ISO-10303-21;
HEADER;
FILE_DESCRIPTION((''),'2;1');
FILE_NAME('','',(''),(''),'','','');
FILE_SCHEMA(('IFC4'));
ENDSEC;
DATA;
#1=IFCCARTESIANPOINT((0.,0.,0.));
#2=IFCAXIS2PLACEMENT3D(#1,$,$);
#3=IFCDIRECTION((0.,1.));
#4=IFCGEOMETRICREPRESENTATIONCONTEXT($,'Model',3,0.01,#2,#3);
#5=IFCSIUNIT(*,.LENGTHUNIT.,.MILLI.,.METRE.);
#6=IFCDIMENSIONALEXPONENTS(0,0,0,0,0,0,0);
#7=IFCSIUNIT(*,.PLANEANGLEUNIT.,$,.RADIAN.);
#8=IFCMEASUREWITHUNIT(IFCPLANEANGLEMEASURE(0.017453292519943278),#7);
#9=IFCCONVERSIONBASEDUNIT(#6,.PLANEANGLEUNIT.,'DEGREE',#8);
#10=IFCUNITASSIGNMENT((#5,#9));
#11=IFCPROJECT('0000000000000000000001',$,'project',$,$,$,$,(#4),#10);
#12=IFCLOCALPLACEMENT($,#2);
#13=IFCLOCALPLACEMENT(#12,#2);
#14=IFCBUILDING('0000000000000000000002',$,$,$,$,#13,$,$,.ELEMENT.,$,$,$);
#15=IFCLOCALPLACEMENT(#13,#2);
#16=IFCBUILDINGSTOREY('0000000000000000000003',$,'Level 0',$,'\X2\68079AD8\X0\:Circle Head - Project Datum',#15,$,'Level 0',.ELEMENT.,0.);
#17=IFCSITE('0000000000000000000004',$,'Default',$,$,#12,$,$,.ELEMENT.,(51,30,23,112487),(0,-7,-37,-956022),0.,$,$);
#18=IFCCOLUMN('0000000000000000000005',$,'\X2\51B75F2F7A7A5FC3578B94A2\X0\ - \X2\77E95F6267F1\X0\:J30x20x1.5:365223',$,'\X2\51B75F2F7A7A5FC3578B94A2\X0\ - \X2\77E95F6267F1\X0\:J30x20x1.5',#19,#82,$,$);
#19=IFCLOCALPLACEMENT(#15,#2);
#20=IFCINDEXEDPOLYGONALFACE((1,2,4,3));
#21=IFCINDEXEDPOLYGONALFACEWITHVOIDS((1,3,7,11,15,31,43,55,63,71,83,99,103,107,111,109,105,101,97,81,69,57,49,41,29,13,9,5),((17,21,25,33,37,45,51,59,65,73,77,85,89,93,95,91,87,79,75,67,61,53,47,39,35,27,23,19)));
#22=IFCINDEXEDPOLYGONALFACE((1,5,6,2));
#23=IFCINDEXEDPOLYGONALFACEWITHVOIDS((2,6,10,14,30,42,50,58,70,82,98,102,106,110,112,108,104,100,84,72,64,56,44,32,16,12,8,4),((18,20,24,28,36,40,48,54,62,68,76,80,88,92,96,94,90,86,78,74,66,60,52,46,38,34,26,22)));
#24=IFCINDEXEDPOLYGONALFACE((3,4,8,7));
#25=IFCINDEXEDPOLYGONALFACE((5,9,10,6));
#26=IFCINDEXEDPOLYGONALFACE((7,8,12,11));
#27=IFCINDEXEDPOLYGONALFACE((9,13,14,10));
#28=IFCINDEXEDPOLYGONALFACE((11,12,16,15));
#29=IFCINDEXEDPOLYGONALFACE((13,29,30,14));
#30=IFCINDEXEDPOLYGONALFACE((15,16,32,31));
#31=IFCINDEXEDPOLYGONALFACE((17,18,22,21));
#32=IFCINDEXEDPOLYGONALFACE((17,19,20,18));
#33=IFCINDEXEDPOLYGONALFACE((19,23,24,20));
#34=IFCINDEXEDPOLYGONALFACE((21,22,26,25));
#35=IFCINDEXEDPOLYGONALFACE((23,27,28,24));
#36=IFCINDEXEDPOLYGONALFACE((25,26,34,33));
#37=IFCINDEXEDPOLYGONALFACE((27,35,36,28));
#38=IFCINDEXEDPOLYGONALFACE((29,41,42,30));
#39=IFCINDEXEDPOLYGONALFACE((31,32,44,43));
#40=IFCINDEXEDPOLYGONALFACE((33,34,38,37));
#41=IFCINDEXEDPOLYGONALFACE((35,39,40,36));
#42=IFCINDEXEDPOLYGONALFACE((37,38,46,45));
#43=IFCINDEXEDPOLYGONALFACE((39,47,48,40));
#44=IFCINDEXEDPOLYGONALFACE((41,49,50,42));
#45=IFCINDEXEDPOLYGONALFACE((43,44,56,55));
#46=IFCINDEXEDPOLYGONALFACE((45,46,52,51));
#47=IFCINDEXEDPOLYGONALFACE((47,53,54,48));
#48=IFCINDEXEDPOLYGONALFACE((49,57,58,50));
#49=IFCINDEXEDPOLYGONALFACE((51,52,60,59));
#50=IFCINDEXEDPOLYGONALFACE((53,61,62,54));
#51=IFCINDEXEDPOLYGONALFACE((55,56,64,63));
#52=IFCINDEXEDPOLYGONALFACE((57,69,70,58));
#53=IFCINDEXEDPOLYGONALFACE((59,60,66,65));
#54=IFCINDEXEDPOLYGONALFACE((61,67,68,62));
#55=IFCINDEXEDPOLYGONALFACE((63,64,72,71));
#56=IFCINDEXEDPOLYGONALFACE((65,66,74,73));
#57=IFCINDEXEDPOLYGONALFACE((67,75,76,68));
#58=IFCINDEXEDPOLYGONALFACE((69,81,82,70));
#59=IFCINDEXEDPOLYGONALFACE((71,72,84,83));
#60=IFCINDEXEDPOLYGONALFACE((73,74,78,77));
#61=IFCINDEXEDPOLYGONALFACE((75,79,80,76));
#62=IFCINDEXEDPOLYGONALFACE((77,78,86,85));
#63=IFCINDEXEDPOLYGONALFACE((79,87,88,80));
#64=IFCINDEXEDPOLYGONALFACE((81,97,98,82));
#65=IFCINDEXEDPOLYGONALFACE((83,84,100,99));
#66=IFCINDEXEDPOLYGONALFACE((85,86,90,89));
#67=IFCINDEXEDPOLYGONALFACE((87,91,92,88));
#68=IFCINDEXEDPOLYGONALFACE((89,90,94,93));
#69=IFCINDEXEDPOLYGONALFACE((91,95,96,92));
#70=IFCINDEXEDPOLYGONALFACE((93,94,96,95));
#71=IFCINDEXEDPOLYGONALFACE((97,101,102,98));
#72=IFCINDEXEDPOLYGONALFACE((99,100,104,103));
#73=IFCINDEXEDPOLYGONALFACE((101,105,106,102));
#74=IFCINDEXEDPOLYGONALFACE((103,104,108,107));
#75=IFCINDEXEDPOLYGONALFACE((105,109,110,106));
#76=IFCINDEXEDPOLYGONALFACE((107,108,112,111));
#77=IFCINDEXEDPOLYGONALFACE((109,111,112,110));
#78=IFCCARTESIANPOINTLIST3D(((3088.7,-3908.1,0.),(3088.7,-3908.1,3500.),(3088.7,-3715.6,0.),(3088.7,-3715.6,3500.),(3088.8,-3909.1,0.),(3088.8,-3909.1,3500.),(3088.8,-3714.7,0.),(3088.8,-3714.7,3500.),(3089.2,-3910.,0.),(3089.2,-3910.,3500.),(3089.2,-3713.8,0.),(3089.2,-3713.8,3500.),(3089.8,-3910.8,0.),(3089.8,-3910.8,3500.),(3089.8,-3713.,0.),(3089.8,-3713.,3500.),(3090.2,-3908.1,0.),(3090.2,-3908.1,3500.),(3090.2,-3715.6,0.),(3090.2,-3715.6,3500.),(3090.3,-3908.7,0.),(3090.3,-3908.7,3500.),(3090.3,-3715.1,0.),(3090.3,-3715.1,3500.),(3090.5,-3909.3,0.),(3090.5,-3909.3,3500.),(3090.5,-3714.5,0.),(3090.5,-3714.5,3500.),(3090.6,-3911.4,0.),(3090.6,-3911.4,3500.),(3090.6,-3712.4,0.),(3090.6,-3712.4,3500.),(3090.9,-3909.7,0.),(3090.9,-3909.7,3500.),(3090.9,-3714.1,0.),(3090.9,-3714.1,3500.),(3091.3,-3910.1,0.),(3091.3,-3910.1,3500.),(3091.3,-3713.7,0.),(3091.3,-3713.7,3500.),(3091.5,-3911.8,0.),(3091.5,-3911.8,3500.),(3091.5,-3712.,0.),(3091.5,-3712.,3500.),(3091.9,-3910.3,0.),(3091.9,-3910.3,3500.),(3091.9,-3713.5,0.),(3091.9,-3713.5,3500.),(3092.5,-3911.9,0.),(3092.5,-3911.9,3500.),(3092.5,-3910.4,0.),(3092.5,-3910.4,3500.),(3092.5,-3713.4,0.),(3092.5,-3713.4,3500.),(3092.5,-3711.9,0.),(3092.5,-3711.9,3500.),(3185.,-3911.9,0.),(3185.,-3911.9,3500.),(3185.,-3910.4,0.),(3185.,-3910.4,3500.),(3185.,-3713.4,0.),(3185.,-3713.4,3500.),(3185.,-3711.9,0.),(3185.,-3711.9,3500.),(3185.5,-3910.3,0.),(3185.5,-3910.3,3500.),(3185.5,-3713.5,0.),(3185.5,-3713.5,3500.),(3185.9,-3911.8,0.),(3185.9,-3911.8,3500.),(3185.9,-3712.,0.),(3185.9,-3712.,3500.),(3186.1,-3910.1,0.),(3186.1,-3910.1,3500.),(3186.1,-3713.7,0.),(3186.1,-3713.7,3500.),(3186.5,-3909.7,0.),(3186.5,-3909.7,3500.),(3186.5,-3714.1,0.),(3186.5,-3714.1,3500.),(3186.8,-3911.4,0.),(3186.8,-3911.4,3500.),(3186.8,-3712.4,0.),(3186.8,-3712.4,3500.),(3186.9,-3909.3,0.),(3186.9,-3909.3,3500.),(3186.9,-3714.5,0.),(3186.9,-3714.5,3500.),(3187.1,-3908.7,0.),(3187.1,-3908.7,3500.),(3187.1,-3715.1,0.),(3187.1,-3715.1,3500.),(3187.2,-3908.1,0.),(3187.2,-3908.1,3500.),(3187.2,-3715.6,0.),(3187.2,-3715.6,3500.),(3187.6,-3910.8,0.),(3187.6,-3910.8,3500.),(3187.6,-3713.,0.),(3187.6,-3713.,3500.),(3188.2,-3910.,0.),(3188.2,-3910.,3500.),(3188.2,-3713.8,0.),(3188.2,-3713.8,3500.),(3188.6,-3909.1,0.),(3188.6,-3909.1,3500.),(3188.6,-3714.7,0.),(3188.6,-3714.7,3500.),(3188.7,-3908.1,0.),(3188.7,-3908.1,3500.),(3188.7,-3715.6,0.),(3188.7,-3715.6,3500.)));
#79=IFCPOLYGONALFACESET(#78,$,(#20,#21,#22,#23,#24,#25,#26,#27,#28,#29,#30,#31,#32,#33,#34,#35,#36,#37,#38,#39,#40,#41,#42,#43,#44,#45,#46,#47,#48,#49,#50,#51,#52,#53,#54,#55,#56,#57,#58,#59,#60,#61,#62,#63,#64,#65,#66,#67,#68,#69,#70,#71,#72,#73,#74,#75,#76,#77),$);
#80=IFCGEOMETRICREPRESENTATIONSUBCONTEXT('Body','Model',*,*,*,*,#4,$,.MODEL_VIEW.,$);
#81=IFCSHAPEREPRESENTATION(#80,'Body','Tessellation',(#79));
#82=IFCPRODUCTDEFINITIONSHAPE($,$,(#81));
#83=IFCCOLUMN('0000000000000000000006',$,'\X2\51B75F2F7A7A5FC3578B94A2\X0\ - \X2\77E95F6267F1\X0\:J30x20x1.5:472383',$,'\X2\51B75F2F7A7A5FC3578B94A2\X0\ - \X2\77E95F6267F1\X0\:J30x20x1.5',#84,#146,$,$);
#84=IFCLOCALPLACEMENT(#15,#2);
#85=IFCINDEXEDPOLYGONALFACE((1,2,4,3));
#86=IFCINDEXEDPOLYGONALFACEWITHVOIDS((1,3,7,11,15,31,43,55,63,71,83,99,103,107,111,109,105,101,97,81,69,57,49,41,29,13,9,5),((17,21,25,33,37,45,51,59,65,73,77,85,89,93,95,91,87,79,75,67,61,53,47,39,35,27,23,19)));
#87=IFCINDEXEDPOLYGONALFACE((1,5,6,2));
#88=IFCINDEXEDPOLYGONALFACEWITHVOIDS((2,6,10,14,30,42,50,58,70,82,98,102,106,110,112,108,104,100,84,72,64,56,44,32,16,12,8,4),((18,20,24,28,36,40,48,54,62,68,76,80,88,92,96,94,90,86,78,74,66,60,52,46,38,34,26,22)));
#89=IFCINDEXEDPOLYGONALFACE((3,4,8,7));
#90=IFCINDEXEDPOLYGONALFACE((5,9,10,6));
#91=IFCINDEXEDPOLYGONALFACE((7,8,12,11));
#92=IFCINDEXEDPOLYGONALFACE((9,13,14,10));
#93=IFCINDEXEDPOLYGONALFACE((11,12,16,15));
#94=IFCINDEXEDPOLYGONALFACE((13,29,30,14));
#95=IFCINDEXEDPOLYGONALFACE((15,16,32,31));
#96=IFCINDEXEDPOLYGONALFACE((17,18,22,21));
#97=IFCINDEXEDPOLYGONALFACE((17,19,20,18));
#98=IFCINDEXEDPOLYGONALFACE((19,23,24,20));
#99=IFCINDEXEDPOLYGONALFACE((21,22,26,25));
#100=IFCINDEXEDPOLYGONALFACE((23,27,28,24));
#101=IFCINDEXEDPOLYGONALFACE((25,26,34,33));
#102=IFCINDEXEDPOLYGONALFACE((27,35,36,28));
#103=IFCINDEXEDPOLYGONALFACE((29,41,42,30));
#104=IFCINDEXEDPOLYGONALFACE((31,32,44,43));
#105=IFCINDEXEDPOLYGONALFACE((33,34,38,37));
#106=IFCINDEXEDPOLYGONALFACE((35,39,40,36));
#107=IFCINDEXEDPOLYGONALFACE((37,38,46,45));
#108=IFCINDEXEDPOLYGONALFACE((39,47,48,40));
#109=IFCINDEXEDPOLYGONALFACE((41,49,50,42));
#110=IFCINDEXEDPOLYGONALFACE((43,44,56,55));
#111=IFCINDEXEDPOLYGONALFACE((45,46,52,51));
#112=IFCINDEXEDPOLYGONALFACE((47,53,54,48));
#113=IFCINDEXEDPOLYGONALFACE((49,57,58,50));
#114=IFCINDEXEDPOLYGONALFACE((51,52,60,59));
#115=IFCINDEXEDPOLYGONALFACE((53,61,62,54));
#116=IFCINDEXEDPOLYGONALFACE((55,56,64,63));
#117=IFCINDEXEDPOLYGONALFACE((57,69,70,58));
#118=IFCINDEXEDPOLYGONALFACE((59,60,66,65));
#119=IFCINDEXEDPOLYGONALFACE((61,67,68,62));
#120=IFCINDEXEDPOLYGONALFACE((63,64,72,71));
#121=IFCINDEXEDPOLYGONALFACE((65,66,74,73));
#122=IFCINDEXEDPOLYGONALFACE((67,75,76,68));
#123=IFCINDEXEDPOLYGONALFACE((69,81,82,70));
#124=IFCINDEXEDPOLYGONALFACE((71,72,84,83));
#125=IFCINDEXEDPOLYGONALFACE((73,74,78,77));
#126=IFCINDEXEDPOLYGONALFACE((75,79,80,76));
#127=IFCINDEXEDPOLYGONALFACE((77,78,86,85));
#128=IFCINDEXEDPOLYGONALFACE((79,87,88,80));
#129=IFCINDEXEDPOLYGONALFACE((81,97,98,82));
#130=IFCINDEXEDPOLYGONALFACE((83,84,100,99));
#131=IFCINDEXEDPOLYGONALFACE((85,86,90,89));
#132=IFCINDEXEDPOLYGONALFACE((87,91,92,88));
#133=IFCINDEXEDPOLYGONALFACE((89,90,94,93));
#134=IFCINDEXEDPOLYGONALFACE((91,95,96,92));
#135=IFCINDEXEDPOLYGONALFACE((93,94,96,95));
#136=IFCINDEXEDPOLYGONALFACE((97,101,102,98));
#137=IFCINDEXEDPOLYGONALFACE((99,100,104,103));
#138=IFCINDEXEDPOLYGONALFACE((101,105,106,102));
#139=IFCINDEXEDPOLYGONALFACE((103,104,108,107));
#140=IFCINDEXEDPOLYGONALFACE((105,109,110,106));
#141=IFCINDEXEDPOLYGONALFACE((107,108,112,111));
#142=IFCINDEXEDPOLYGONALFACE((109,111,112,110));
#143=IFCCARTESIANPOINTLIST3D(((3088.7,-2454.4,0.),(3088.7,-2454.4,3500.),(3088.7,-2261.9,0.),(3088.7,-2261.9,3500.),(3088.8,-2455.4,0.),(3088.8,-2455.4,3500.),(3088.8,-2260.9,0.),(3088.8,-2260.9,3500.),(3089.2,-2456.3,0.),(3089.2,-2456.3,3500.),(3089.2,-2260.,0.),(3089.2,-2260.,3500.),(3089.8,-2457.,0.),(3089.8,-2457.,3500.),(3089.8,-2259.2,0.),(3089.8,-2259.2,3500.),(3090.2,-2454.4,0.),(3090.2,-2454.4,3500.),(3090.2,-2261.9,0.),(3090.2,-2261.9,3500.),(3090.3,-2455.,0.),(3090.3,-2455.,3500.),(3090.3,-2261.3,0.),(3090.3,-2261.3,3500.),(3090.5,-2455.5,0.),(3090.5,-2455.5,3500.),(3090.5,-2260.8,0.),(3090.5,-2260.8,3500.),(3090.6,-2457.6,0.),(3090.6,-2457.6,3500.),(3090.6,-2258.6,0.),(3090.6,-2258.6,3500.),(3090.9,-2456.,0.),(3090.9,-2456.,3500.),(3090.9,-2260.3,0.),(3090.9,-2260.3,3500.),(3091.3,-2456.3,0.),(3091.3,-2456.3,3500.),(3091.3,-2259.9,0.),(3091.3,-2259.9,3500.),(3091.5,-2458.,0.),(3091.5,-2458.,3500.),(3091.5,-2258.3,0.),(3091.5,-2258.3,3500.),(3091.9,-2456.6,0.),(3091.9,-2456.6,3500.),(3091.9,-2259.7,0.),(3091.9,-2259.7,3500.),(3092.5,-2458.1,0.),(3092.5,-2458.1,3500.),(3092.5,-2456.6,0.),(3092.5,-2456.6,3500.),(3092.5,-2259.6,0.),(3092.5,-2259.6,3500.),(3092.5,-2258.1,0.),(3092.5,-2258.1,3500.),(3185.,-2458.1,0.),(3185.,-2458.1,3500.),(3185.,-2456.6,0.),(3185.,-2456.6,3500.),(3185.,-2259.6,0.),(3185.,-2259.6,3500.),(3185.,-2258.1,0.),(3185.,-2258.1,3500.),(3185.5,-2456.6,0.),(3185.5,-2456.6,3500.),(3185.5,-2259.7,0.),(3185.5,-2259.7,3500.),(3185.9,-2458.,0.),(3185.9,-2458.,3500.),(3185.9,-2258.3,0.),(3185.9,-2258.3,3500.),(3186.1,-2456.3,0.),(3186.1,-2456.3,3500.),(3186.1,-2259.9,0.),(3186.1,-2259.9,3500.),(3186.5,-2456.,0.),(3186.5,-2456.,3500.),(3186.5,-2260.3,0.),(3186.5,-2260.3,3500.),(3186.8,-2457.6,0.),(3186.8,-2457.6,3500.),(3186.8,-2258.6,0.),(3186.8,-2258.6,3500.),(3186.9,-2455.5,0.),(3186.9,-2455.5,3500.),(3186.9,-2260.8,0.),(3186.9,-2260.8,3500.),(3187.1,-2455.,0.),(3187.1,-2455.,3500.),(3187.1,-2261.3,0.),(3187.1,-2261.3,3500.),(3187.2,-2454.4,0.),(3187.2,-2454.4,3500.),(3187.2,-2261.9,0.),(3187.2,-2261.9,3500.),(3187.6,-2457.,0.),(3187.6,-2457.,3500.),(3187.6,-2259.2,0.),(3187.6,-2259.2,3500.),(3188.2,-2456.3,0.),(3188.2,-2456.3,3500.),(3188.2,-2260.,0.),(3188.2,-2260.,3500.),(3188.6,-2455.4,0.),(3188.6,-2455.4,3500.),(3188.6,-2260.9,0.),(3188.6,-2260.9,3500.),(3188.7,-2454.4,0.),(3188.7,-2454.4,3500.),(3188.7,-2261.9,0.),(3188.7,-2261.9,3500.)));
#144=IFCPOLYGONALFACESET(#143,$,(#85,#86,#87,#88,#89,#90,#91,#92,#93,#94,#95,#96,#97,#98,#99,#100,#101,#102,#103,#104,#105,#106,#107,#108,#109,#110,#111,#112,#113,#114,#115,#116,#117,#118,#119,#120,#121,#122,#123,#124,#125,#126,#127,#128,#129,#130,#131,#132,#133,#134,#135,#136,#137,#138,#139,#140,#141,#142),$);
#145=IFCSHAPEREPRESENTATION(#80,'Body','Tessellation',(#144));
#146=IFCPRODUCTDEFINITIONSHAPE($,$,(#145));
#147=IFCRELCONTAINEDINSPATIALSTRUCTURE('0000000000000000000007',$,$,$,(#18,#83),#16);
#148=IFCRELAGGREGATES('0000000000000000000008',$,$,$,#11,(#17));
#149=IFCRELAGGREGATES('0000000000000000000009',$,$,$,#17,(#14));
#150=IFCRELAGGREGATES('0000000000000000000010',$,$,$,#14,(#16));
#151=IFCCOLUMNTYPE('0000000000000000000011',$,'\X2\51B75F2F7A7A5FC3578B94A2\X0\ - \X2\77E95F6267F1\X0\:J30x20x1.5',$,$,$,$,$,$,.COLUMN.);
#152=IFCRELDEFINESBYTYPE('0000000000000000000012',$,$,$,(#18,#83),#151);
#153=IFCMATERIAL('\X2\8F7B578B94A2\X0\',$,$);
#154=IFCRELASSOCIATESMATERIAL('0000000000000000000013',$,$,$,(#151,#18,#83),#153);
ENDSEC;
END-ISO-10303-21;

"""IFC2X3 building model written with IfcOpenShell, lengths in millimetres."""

from ifc_helpers import new_model, entity, si_unit, converted_unit, direction, frame, frame_2d, origin, place, context, subcontext, project, spatial, polyline, circle_curve, parameter, trimmed, segment, composite_curve, outline, extrude, source, transform, mapped, material, type_object, type_shapes, element, save


model = new_model("IFC2X3")

# Units and contexts
model_context = context("Model", 3, precision=0.01, world=origin(), true_north=direction((0.0, 1.0)))
body_context = subcontext(model_context, "Body", "Model", "MODEL_VIEW")
ifc_project = project(units=[si_unit("LENGTHUNIT", "METRE", prefix="MILLI"), converted_unit("PLANEANGLEUNIT", "DEGREE", entity("IfcPlaneAngleMeasure", 0.017453292519943278), si_unit("PLANEANGLEUNIT", "RADIAN"), dimensions=[0, 0, 0, 0, 0, 0, 0])], contexts=[model_context])

# Site, building, storey
site_placement = place(None, origin())
site = spatial("IfcSite", under=ifc_project, at=site_placement, Name="Default", CompositionType="ELEMENT", RefLatitude=(51, 30, 23, 112487), RefLongitude=(0, -7, -37, -956022), RefElevation=0.0)
building_placement = place(site_placement, origin())
building = spatial("IfcBuilding", under=site, at=building_placement, CompositionType="ELEMENT")
storey_placement = place(building_placement, origin())
storey = spatial("IfcBuildingStorey", under=building, at=storey_placement, Name="Level 0", ObjectType="标高:Circle Head - Project Datum", LongName="Level 0", CompositionType="ELEMENT", Elevation=0.0)

# Columns
ifc_material_1 = material(Name="轻型钢")
column_type = type_object("IfcColumnType", Name="冷弯空心型钢 - 矩形柱:J30x20x1.5", PredefinedType="COLUMN", material=ifc_material_1)
shared_shape = source(origin(), body_context, "Body", "SweptSolid", [
    extrude(outline(composite_curve([segment(polyline([(-46.2, -100.0), (46.3, -100.0)]), True, "CONTINUOUS"), segment(trimmed(circle_curve(frame_2d((46.3, -96.3), x_axis=(-1.0, 0.0)), 3.8), [parameter(90.0)], [parameter(180.0)], True, "PARAMETER"), True, "CONTINUOUS"), segment(polyline([(50.0, -96.3), (50.0, 96.3)]), True, "CONTINUOUS"), segment(trimmed(circle_curve(frame_2d((46.2, 96.3), x_axis=(-1.0, 0.0)), 3.8), [parameter(180.0)], [parameter(270.0)], True, "PARAMETER"), True, "CONTINUOUS"), segment(polyline([(46.2, 100.0), (-46.2, 100.0)]), True, "CONTINUOUS"), segment(trimmed(circle_curve(frame_2d((-46.2, 96.3), x_axis=(-1.0, 0.0)), 3.8), [parameter(270.0)], [parameter(0.0)], True, "PARAMETER"), True, "CONTINUOUS"), segment(polyline([(-50.0, 96.3), (-50.0, -96.3)]), True, "CONTINUOUS"), segment(trimmed(circle_curve(frame_2d((-46.2, -96.3), x_axis=(-1.0, 0.0)), 3.8), [parameter(360.0)], [parameter(90.0)], True, "PARAMETER"), True, "CONTINUOUS")], self_intersect=False), holes=[composite_curve([segment(trimmed(circle_curve(frame_2d((-46.3, -96.3), x_axis=(-1.0, 0.0)), 2.2), [parameter(0.0)], [parameter(90.0)], True, "PARAMETER"), False, "CONTINUOUS"), segment(polyline([(-48.5, -96.3), (-48.5, 96.3)]), True, "CONTINUOUS"), segment(trimmed(circle_curve(frame_2d((-46.3, 96.3), x_axis=(-1.0, 0.0)), 2.2), [parameter(270.0)], [parameter(0.0)], True, "PARAMETER"), False, "CONTINUOUS"), segment(polyline([(-46.3, 98.5), (46.2, 98.5)]), True, "CONTINUOUS"), segment(trimmed(circle_curve(frame_2d((46.2, 96.3), x_axis=(-1.0, 0.0)), 2.2), [parameter(180.0)], [parameter(270.0)], True, "PARAMETER"), False, "CONTINUOUS"), segment(polyline([(48.5, 96.3), (48.5, -96.3)]), True, "CONTINUOUS"), segment(trimmed(circle_curve(frame_2d((46.3, -96.3), x_axis=(-1.0, 0.0)), 2.2), [parameter(90.0)], [parameter(180.0)], True, "PARAMETER"), False, "CONTINUOUS"), segment(polyline([(46.3, -98.5), (-46.3, -98.5)]), True, "CONTINUOUS")], self_intersect=False)]), frame((0.0, 0.0, 0.0), z_axis=(0.0, 0.0, 1.0), x_axis=(-1.0, 0.0, 0.0)), (0.0, 0.0, 1.0), 3500.0),
])
type_shapes(column_type, [shared_shape])
for number, where, z_axis, x_axis, name in (
    (1, (3138.7, -3811.9, 0.0), (0.0, 0.0, 1.0), (-1.0, 0.0, 0.0), "冷弯空心型钢 - 矩形柱:J30x20x1.5:365223"),
    (2, (3138.7, -2358.1, 0.0), (0.0, 0.0, 1.0), (-1.0, 0.0, 0.0), "冷弯空心型钢 - 矩形柱:J30x20x1.5:472383"),
):
    element("IfcColumn", number, at=place(storey_placement, frame(where, z_axis=z_axis, x_axis=x_axis)), inside=storey, type_object=column_type, material=ifc_material_1, Name=name, ObjectType="冷弯空心型钢 - 矩形柱:J30x20x1.5", context=body_context, shape_type="MappedRepresentation", body=[
        mapped(shared_shape, transform((0.0, 0.0, 0.0), scale=1.0)),
    ])

save(model, "model.ifc")
